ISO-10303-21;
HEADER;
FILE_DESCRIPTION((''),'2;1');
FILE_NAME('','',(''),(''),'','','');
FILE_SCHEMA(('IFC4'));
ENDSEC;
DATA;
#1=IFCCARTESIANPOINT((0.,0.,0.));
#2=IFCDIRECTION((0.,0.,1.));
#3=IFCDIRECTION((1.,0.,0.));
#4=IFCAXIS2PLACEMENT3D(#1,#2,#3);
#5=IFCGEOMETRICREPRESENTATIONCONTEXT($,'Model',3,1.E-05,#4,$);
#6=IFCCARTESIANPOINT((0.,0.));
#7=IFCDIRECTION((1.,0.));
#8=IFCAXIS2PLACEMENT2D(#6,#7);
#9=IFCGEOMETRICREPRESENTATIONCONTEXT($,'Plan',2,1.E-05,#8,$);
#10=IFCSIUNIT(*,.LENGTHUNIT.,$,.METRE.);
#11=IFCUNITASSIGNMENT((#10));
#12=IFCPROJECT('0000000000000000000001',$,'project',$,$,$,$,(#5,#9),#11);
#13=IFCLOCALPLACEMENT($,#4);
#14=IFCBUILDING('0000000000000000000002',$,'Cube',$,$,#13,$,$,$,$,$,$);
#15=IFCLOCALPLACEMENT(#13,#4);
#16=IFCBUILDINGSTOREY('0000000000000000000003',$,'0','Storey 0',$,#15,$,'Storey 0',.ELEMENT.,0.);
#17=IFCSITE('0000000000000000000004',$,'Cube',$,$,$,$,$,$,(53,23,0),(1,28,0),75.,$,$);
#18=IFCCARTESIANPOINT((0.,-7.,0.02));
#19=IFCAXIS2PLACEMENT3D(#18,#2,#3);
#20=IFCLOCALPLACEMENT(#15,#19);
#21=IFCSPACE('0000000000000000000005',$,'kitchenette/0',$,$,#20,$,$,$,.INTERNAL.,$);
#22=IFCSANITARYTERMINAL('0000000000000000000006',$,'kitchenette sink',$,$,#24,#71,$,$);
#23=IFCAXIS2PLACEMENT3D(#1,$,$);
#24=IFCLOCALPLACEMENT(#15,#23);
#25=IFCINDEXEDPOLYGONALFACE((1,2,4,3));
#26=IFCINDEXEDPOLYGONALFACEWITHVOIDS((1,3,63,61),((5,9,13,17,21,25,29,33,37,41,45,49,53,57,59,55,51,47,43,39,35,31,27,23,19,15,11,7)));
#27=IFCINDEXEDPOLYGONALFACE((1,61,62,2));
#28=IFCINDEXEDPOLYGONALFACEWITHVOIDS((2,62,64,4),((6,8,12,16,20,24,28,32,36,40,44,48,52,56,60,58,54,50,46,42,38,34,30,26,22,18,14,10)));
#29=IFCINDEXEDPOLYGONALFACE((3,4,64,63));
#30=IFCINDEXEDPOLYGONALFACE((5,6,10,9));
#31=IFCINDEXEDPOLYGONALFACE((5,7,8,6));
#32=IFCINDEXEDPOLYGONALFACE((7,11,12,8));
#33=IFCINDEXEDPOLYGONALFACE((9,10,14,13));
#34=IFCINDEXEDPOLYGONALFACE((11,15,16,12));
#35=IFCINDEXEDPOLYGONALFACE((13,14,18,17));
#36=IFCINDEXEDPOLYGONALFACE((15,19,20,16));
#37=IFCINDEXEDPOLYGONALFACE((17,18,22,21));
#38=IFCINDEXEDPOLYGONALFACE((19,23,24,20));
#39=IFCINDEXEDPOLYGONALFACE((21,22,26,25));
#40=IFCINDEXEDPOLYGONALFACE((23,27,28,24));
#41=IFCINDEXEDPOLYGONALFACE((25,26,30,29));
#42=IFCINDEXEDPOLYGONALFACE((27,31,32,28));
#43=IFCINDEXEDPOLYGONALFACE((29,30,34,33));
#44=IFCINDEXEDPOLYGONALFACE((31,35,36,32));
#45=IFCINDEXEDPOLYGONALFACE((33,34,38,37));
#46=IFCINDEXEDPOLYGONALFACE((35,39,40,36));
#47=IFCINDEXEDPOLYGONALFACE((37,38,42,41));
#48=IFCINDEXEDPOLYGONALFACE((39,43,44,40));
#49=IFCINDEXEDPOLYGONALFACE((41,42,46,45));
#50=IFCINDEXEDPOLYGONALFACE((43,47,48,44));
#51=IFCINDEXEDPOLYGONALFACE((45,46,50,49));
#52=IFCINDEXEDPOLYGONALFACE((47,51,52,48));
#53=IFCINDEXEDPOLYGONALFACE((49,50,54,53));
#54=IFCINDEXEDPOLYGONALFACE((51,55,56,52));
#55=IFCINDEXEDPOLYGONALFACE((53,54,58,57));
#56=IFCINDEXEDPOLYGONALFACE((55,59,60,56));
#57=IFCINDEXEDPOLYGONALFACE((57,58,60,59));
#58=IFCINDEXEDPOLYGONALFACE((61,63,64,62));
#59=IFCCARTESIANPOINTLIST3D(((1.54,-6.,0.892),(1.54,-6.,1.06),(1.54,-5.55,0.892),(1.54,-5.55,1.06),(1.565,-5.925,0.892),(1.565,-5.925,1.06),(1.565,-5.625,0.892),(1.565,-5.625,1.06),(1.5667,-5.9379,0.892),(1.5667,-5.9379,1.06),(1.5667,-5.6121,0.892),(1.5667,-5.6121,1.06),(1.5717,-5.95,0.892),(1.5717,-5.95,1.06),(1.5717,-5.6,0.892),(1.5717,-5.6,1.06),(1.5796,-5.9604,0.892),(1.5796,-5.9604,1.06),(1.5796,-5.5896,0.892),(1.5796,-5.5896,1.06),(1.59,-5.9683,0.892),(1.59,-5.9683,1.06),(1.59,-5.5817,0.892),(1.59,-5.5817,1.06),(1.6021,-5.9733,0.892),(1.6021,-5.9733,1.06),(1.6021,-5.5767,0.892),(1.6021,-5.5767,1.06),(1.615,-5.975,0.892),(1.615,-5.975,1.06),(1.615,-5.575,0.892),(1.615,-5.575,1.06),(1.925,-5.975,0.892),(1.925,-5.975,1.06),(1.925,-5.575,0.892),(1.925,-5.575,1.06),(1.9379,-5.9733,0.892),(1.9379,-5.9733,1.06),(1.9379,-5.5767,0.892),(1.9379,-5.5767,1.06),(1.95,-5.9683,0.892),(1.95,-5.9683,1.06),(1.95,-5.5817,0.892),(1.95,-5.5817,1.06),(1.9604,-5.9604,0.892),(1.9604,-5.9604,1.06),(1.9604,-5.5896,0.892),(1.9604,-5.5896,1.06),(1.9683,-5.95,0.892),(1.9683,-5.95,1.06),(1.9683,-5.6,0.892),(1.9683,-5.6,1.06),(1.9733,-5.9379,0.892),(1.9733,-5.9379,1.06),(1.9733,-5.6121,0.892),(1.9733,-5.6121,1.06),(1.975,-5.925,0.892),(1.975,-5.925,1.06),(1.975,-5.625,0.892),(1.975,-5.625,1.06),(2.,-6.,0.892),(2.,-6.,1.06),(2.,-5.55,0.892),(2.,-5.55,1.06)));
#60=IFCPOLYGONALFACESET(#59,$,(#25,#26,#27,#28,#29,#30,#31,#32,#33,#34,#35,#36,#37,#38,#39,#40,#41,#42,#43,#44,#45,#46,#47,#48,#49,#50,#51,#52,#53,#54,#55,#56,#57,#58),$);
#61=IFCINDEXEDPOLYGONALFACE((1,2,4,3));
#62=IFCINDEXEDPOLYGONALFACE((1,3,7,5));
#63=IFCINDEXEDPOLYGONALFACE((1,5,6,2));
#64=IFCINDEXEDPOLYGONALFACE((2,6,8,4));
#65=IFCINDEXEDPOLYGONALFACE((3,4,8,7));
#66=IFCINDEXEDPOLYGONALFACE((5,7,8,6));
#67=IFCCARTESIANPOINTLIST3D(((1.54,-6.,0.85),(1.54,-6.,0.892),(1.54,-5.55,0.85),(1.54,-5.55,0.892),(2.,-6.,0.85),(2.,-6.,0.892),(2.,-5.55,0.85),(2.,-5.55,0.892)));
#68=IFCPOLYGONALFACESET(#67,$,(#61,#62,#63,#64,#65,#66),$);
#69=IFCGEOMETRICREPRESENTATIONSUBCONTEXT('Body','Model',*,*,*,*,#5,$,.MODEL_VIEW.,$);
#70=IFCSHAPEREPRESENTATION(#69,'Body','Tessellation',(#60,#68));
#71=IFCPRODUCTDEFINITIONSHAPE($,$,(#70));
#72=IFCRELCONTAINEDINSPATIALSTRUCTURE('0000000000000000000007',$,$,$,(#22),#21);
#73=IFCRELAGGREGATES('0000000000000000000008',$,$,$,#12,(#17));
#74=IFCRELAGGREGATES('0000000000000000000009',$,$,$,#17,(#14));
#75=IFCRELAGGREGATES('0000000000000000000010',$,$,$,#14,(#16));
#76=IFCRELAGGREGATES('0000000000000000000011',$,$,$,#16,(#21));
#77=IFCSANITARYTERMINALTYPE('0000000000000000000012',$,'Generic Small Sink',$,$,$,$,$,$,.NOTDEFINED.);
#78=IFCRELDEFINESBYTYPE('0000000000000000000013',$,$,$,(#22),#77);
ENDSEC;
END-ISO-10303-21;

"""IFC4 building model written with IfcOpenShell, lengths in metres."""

from ifc_helpers import new_model, entity, si_unit, frame, origin_with_axes, origin_2d_with_axis, place, context, subcontext, project, spatial, shape, source, transform, mapped, type_object, type_shapes, element, save


model = new_model("IFC4")

# Units and contexts
model_context = context("Model", 3, precision=1e-05, world=origin_with_axes())
plan_context = context("Plan", 2, precision=1e-05, world=origin_2d_with_axis())
body_context_1 = subcontext(model_context, "Body", "Model", "MODEL_VIEW")
body_context_2 = subcontext(plan_context, "Body", "Plan", "PLAN_VIEW")
ifc_project = project(units=[si_unit("LENGTHUNIT", "METRE")], contexts=[model_context, plan_context])

# Site, building, storey
site = spatial("IfcSite", under=ifc_project, Name="Cube", RefLatitude=(53, 23, 0), RefLongitude=(1, 28, 0), RefElevation=75.0)
building_placement = place(None, origin_with_axes())
building = spatial("IfcBuilding", under=site, at=building_placement, Name="Cube")
storey_placement = place(building_placement, origin_with_axes())
storey = spatial("IfcBuildingStorey", under=building, at=storey_placement, Name="0", Description="Storey 0", LongName="Storey 0", CompositionType="ELEMENT", Elevation=0.0)

# Shared definitions
space_1_placement = place(storey_placement, frame((0.0, -7.0, 0.02), z_axis=(0.0, 0.0, 1.0), x_axis=(1.0, 0.0, 0.0)))
space_1 = spatial("IfcSpace", under=storey, at=space_1_placement, Name="kitchenette/0", PredefinedType="INTERNAL")

# Sanitary terminal
sanitary_terminal_type_1 = type_object("IfcSanitaryTerminalType", Name="Generic Small Sink", PredefinedType="NOTDEFINED")
shared_indexed_poly_curve_1 = entity("IfcIndexedPolyCurve", entity("IfcCartesianPointList2D", [[0.0, 0.0], [0.45, 0.0], [0.45, 0.46], [0.0, 0.46]]), [entity("IfcLineIndex", [1, 2, 3, 4, 1])])
shared_shape_1 = source(origin_with_axes(), body_context_1, "Body", "SweptSolid", [
    entity("IfcExtrudedAreaSolid", entity("IfcArbitraryProfileDefWithVoids", "AREA", None, shared_indexed_poly_curve_1, [entity("IfcIndexedPolyCurve", entity("IfcCartesianPointList2D", [[0.025, 0.075], [0.0396, 0.0396], [0.075, 0.025], [0.375, 0.025], [0.4104, 0.0396], [0.425, 0.075], [0.425, 0.385], [0.4104, 0.4204], [0.375, 0.435], [0.075, 0.435], [0.0396, 0.4204], [0.025, 0.385]]), [entity("IfcLineIndex", [12, 1]), entity("IfcArcIndex", [1, 2, 3]), entity("IfcLineIndex", [3, 4]), entity("IfcArcIndex", [4, 5, 6]), entity("IfcLineIndex", [6, 7]), entity("IfcArcIndex", [7, 8, 9]), entity("IfcLineIndex", [9, 10]), entity("IfcArcIndex", [10, 11, 12]), entity("IfcLineIndex", [12, 1])])]), entity("IfcAxis2Placement3D", entity("IfcCartesianPoint", [-0.225, -0.46, 0.042]), entity("IfcDirection", [0.0, 0.0, 1.0]), entity("IfcDirection", [1.0, 0.0, 0.0])), entity("IfcDirection", [0.0, 0.0, 1.0]), 0.168),
    entity("IfcExtrudedAreaSolid", entity("IfcArbitraryClosedProfileDef", "AREA", None, shared_indexed_poly_curve_1), entity("IfcAxis2Placement3D", entity("IfcCartesianPoint", [-0.225, -0.46, 0.0]), entity("IfcDirection", [0.0, 0.0, 1.0]), entity("IfcDirection", [1.0, 0.0, 0.0])), entity("IfcDirection", [0.0, 0.0, 1.0]), 0.042),
])
shared_shape_2 = source(origin_with_axes(), body_context_2, "Body", "Curve2D", [
    entity("IfcIndexedPolyCurve", entity("IfcCartesianPointList2D", [[-0.225, -0.46], [0.225, -0.46], [0.225, 0.0], [-0.225, 0.0]]), [entity("IfcLineIndex", [1, 2, 3, 4, 1])]),
    entity("IfcIndexedPolyCurve", entity("IfcCartesianPointList2D", [[-0.2, -0.385], [-0.1854, -0.4204], [-0.15, -0.435], [0.15, -0.435], [0.1854, -0.4204], [0.2, -0.385], [0.2, -0.075], [0.1854, -0.0396], [0.15, -0.025], [-0.15, -0.025], [-0.1854, -0.0396], [-0.2, -0.075]]), [entity("IfcLineIndex", [12, 1]), entity("IfcArcIndex", [1, 2, 3]), entity("IfcLineIndex", [3, 4]), entity("IfcArcIndex", [4, 5, 6]), entity("IfcLineIndex", [6, 7]), entity("IfcArcIndex", [7, 8, 9]), entity("IfcLineIndex", [9, 10]), entity("IfcArcIndex", [10, 11, 12]), entity("IfcLineIndex", [12, 1])]),
    entity("IfcCircle", entity("IfcAxis2Placement2D", entity("IfcCartesianPoint", [0.0, -0.125])), 0.025),
    entity("IfcIndexedPolyCurve", entity("IfcCartesianPointList2D", [[0.0, -0.0125], [0.0, -0.1325]])),
])
type_shapes(sanitary_terminal_type_1, [shared_shape_1, shared_shape_2])
sanitary_terminal_1_placement = place(space_1_placement, frame((2.0, 1.225, 0.83), z_axis=(0.0, 0.0, 1.0), x_axis=(0.0, -1.0, 0.0)))
element("IfcSanitaryTerminal", 1, at=sanitary_terminal_1_placement, inside=space_1, type_object=sanitary_terminal_type_1, Name="kitchenette sink", shapes=[
    shape(body_context_1, "Body", "MappedRepresentation", [mapped(shared_shape_1, transform((0.0, 0.0, 0.0), x_axis=(1.0, 0.0, 0.0), y_axis=(0.0, 1.0, 0.0), z_axis=(0.0, 0.0, 1.0), scale=1.0))]),
    shape(body_context_2, "Body", "MappedRepresentation", [mapped(shared_shape_2, transform((0.0, 0.0, 0.0), x_axis=(1.0, 0.0, 0.0), y_axis=(0.0, 1.0, 0.0), z_axis=(0.0, 0.0, 1.0), scale=1.0))]),
])

save(model, "model.ifc")
